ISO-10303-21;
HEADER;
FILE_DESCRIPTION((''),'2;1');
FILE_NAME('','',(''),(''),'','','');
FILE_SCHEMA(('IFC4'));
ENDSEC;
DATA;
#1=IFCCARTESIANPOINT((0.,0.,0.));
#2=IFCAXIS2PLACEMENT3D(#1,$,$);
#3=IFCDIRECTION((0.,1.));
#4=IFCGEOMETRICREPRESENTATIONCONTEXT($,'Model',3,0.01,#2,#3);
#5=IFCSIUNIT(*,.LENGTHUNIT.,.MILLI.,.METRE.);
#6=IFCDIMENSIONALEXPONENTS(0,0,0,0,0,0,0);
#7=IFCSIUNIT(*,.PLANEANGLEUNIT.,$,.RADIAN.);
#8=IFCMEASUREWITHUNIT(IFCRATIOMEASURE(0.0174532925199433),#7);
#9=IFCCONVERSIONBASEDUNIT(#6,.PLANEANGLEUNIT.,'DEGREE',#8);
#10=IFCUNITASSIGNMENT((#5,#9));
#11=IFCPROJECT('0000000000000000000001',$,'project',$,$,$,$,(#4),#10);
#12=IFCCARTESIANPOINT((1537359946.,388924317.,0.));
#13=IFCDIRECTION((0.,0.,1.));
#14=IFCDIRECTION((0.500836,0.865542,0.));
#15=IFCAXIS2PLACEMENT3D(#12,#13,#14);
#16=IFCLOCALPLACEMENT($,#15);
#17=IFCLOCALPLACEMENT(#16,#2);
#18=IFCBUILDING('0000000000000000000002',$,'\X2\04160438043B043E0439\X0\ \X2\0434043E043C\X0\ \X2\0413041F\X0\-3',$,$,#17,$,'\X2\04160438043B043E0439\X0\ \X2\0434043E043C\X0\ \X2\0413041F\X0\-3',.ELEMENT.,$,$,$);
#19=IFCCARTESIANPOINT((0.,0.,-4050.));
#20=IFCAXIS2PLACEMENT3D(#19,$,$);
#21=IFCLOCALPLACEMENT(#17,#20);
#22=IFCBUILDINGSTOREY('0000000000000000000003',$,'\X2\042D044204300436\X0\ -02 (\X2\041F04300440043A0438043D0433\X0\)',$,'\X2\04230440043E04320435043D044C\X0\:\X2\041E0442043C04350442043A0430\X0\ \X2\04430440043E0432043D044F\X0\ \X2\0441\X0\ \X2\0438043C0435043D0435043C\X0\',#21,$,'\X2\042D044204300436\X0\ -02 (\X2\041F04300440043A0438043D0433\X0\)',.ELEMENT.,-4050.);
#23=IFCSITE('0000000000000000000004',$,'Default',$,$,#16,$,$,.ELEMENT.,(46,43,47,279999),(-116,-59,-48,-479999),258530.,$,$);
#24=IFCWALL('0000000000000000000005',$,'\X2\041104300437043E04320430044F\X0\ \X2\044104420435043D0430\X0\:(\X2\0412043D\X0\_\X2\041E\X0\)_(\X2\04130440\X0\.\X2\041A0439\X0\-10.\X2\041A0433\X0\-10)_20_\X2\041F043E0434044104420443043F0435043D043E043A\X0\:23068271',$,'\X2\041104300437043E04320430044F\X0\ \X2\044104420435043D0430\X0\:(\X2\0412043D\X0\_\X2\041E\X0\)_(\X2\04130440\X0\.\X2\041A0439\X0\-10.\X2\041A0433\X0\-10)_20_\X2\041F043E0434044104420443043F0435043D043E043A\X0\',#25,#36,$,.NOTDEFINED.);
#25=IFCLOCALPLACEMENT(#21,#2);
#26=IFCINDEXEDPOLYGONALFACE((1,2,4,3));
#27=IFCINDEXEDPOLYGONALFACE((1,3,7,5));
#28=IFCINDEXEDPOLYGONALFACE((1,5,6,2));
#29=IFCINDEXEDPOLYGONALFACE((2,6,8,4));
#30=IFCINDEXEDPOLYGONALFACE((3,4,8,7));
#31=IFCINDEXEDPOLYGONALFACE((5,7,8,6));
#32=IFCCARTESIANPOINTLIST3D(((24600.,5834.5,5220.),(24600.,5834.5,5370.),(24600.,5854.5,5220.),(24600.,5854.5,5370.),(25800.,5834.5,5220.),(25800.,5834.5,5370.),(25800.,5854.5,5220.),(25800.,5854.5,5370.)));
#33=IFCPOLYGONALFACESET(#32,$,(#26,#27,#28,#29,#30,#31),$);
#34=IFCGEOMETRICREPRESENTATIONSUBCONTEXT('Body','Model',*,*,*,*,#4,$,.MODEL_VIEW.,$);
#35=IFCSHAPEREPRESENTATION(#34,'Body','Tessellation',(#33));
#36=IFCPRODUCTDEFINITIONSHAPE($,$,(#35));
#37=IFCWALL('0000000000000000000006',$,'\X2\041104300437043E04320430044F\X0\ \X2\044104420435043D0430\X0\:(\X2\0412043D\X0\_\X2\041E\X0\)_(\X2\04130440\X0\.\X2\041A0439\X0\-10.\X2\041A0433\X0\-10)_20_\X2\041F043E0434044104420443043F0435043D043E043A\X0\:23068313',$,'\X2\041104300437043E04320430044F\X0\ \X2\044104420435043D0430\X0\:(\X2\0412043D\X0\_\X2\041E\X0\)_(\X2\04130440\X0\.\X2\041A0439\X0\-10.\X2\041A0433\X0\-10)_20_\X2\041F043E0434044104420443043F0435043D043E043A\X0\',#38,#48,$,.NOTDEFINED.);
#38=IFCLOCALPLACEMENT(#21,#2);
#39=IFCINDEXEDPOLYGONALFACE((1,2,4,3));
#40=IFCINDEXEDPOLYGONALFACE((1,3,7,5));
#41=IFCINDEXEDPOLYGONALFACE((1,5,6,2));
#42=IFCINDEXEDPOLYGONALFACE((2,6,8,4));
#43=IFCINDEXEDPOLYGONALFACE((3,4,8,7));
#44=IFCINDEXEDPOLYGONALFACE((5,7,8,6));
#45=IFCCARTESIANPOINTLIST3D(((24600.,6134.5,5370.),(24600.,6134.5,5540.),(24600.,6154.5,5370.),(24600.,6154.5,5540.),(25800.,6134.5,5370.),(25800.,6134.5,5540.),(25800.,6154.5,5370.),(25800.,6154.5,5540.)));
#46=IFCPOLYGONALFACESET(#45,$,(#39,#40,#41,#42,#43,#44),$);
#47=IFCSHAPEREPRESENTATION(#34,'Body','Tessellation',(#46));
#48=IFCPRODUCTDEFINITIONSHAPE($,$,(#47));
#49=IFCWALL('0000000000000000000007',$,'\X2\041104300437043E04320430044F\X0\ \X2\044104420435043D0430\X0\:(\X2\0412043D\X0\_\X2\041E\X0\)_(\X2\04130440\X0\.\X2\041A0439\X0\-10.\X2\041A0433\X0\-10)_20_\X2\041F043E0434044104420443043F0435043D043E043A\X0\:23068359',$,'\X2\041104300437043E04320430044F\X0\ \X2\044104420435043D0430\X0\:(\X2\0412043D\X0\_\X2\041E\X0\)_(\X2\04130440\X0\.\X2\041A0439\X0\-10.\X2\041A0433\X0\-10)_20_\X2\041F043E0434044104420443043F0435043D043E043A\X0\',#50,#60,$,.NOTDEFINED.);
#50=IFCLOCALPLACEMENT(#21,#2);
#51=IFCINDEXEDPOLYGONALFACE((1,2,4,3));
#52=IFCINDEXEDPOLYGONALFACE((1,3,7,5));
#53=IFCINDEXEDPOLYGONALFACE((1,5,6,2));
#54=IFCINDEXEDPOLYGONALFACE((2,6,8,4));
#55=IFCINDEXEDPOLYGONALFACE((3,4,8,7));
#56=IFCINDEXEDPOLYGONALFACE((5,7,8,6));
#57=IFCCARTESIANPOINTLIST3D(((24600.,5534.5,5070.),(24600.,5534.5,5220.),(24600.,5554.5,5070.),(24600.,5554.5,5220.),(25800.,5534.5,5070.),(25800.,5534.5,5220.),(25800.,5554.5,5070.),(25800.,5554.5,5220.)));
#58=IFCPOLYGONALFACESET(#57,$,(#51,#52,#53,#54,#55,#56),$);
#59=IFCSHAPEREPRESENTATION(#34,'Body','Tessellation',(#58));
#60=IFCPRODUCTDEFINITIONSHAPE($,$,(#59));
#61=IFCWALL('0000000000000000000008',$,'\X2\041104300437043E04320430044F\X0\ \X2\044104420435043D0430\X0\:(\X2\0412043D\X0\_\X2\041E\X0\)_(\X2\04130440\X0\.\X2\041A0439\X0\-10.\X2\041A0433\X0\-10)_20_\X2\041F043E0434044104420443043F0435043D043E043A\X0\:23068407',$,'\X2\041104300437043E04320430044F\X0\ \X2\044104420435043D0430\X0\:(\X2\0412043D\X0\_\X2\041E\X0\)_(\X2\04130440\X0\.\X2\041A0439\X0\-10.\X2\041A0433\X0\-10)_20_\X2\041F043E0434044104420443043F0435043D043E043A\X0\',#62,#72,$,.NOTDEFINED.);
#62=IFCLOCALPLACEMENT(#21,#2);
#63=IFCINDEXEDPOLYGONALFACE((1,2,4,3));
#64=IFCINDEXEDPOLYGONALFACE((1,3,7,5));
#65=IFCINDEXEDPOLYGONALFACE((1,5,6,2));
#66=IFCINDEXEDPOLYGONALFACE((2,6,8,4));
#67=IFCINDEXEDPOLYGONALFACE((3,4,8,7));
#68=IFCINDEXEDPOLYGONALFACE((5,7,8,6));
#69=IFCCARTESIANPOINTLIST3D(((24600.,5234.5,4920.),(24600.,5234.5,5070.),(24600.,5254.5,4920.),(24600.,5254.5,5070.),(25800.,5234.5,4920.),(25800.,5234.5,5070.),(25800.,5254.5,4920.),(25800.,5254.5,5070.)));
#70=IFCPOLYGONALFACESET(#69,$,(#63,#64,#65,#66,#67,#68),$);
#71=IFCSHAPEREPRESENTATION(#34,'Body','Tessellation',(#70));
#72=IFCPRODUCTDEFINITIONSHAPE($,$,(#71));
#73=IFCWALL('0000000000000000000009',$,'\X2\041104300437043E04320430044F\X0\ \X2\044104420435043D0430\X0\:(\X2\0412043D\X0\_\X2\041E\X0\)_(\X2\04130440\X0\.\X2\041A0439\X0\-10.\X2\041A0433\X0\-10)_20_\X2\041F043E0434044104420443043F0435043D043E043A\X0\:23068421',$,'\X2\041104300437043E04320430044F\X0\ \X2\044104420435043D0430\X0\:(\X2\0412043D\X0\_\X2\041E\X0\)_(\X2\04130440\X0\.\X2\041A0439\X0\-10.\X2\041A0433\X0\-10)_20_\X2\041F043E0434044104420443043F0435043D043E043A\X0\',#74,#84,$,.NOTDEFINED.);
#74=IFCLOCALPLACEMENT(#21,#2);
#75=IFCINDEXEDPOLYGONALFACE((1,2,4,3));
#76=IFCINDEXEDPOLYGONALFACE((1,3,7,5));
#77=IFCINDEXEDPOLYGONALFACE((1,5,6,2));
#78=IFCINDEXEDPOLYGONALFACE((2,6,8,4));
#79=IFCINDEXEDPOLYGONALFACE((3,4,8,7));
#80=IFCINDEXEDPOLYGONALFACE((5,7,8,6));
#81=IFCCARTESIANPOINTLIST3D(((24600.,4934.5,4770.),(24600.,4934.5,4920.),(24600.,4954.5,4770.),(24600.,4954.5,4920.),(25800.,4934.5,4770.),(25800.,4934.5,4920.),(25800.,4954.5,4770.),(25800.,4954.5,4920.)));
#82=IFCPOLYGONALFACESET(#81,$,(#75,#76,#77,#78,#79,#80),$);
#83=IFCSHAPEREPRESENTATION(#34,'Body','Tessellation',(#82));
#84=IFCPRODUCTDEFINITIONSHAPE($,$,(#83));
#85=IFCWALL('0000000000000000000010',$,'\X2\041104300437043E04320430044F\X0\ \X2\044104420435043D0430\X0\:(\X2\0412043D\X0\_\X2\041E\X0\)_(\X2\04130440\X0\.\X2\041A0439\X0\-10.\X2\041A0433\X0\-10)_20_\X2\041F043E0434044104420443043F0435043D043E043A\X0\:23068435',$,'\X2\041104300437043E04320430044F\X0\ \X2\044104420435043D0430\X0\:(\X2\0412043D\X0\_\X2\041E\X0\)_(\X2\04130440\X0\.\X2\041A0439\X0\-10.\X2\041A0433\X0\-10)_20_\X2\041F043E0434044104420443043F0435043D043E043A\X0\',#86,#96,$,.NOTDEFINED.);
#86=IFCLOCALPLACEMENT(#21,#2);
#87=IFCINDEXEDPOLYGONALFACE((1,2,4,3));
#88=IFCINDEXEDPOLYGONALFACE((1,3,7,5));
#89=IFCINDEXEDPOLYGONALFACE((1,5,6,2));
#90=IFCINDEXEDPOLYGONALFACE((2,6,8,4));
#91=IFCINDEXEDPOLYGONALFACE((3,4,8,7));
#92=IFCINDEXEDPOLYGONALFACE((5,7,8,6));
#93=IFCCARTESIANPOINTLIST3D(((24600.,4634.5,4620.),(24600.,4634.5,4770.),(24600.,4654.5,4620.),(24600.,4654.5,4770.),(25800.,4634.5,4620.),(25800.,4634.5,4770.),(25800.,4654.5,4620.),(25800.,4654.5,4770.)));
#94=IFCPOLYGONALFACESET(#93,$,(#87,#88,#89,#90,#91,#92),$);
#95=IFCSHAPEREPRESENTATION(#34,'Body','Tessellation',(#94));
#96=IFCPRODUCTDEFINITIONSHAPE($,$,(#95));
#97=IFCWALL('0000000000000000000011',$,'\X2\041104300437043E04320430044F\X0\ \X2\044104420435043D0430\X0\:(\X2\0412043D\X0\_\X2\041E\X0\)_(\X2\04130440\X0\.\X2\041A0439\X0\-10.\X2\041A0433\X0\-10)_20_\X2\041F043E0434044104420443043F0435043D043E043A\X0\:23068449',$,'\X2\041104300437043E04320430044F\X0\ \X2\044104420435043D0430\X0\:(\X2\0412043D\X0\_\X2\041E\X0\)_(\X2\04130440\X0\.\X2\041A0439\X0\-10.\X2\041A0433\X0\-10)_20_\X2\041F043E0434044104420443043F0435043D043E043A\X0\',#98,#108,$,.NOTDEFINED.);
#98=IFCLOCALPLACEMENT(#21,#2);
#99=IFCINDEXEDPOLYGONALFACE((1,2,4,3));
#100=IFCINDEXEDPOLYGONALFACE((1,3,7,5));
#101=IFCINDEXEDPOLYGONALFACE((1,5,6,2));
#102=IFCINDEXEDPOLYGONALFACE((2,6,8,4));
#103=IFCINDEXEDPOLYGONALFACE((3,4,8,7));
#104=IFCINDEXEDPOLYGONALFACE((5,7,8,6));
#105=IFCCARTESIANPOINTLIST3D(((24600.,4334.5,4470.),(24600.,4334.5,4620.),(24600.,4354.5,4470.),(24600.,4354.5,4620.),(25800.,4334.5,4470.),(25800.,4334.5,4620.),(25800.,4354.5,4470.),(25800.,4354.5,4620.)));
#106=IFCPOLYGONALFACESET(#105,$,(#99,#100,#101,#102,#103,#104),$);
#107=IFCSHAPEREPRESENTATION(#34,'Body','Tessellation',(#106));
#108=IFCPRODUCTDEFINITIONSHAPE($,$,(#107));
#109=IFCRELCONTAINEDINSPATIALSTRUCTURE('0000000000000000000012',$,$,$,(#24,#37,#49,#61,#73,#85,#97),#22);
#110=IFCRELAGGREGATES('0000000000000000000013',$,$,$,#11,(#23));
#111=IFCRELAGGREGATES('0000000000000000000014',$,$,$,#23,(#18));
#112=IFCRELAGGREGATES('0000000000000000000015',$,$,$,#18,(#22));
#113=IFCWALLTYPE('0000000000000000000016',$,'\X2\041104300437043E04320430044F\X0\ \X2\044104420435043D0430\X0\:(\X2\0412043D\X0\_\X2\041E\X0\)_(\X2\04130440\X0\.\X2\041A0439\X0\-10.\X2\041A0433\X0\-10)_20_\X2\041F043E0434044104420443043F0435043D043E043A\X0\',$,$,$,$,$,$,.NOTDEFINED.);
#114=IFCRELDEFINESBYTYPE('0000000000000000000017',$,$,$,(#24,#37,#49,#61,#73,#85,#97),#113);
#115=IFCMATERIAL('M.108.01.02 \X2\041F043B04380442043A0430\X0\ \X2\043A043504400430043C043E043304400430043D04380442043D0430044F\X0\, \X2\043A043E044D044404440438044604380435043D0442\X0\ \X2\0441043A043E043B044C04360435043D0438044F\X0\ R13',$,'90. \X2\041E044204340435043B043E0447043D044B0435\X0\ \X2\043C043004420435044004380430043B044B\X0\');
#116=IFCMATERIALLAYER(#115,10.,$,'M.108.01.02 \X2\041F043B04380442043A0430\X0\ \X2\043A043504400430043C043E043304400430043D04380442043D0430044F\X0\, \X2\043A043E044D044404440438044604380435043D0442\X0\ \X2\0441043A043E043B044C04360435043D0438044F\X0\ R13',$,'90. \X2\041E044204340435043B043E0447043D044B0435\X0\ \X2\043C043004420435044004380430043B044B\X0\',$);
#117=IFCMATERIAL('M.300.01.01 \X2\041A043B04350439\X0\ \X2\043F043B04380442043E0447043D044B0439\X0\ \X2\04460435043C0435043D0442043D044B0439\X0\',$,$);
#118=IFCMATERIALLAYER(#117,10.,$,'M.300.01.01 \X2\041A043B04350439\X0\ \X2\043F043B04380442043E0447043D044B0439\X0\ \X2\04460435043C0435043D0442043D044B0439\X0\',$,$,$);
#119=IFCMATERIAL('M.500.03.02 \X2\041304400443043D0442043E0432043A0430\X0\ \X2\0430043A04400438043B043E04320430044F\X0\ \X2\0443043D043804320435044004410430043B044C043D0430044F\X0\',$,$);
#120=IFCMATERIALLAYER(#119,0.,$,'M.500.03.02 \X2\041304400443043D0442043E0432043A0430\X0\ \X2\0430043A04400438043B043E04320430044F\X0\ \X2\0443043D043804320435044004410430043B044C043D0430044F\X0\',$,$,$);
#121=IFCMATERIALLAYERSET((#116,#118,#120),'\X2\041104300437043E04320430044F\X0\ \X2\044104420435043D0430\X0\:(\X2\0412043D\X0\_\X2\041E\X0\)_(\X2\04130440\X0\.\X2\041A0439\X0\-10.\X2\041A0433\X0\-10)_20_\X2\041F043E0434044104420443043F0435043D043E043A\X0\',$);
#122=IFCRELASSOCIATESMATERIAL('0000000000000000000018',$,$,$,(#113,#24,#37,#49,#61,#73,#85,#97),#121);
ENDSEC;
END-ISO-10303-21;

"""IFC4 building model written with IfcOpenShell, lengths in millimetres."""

from ifc_helpers import new_model, entity, si_unit, converted_unit, direction, frame, frame_2d, origin, place, context, subcontext, project, spatial, rectangle, extrude, material, layer, layer_set, layer_usage, type_object, element, save


model = new_model("IFC4")

# Units and contexts
model_context = context("Model", 3, precision=0.01, world=origin(), true_north=direction((0.0, 1.0)))
body_context = subcontext(model_context, "Body", "Model", "MODEL_VIEW")
ifc_project = project(units=[si_unit("LENGTHUNIT", "METRE", prefix="MILLI"), converted_unit("PLANEANGLEUNIT", "DEGREE", entity("IfcRatioMeasure", 0.0174532925199433), si_unit("PLANEANGLEUNIT", "RADIAN"), dimensions=[0, 0, 0, 0, 0, 0, 0])], contexts=[model_context])

# Site, building, storey
site_placement = place(None, frame((1537359946.0, 388924317.0, 0.0), z_axis=(0.0, 0.0, 1.0), x_axis=(0.500836, 0.865542, 0.0)))
site = spatial("IfcSite", under=ifc_project, at=site_placement, Name="Default", CompositionType="ELEMENT", RefLatitude=(46, 43, 47, 279999), RefLongitude=(-116, -59, -48, -479999), RefElevation=258530.0)
building_placement = place(site_placement, origin())
building = spatial("IfcBuilding", under=site, at=building_placement, Name="Жилой дом ГП-3", LongName="Жилой дом ГП-3", CompositionType="ELEMENT")
storey_placement = place(building_placement, frame((0.0, 0.0, -4050.0)))
storey = spatial("IfcBuildingStorey", under=building, at=storey_placement, Name="Этаж -02 (Паркинг)", ObjectType="Уровень:Отметка уровня с именем", LongName="Этаж -02 (Паркинг)", CompositionType="ELEMENT", Elevation=-4050.0)

# Walls
ifc_material_1 = material(Name="M.108.01.02 Плитка керамогранитная, коэффициент скольжения R13", Category="90. Отделочные материалы")
ifc_layer_1 = layer(ifc_material_1, 10.0, Name="M.108.01.02 Плитка керамогранитная, коэффициент скольжения R13", Category="90. Отделочные материалы")
ifc_material_2 = material(Name="M.300.01.01 Клей плиточный цементный")
ifc_layer_2 = layer(ifc_material_2, 10.0, Name="M.300.01.01 Клей плиточный цементный")
ifc_material_3 = material(Name="M.500.03.02 Грунтовка акриловая универсальная")
ifc_layer_3 = layer(ifc_material_3, 0.0, Name="M.500.03.02 Грунтовка акриловая универсальная")
ifc_layer_set = layer_set([ifc_layer_1, ifc_layer_2, ifc_layer_3], Name="Базовая стена:(Вн_О)_(Гр.Кй-10.Кг-10)_20_Подступенок")
ifc_layer_usage_1 = layer_usage(ifc_layer_set, "AXIS2", "NEGATIVE", 10.0)
wall_type = type_object("IfcWallType", Name="Базовая стена:(Вн_О)_(Гр.Кй-10.Кг-10)_20_Подступенок", PredefinedType="NOTDEFINED", material=ifc_layer_set)
wall_1_placement = place(storey_placement, frame((25800.0, 5844.5, 5220.0), z_axis=(0.0, 0.0, 1.0), x_axis=(-1.0, 0.0, 0.0)))
element("IfcWall", 1, at=wall_1_placement, inside=storey, type_object=wall_type, material=ifc_layer_usage_1, Name="Базовая стена:(Вн_О)_(Гр.Кй-10.Кг-10)_20_Подступенок:23068271", ObjectType="Базовая стена:(Вн_О)_(Гр.Кй-10.Кг-10)_20_Подступенок", PredefinedType="NOTDEFINED", context=body_context, shape_type="SweptSolid", body=[
    extrude(rectangle(XDim=1200.0, YDim=20.0, at=frame_2d((600.0, 0.0), x_axis=(-1.0, 0.0))), origin(), (0.0, 0.0, 1.0), 150.0),
])
ifc_layer_usage_2 = layer_usage(ifc_layer_set, "AXIS2", "NEGATIVE", 10.0)
wall_2_placement = place(storey_placement, frame((25800.0, 6144.5, 5370.0), z_axis=(0.0, 0.0, 1.0), x_axis=(-1.0, 0.0, 0.0)))
element("IfcWall", 2, at=wall_2_placement, inside=storey, type_object=wall_type, material=ifc_layer_usage_2, Name="Базовая стена:(Вн_О)_(Гр.Кй-10.Кг-10)_20_Подступенок:23068313", ObjectType="Базовая стена:(Вн_О)_(Гр.Кй-10.Кг-10)_20_Подступенок", PredefinedType="NOTDEFINED", context=body_context, shape_type="SweptSolid", body=[
    extrude(rectangle(XDim=1200.0, YDim=20.0, at=frame_2d((600.0, 0.0), x_axis=(-1.0, 0.0))), origin(), (0.0, 0.0, 1.0), 170.0),
])
ifc_layer_usage_3 = layer_usage(ifc_layer_set, "AXIS2", "NEGATIVE", 10.0)
wall_3_placement = place(storey_placement, frame((25800.0, 5544.5, 5070.0), z_axis=(0.0, 0.0, 1.0), x_axis=(-1.0, 0.0, 0.0)))
element("IfcWall", 3, at=wall_3_placement, inside=storey, type_object=wall_type, material=ifc_layer_usage_3, Name="Базовая стена:(Вн_О)_(Гр.Кй-10.Кг-10)_20_Подступенок:23068359", ObjectType="Базовая стена:(Вн_О)_(Гр.Кй-10.Кг-10)_20_Подступенок", PredefinedType="NOTDEFINED", context=body_context, shape_type="SweptSolid", body=[
    extrude(rectangle(XDim=1200.0, YDim=20.0, at=frame_2d((600.0, 0.0), x_axis=(-1.0, 0.0))), origin(), (0.0, 0.0, 1.0), 150.0),
])
ifc_layer_usage_4 = layer_usage(ifc_layer_set, "AXIS2", "NEGATIVE", 10.0)
wall_4_placement = place(storey_placement, frame((25800.0, 5244.5, 4920.0), z_axis=(0.0, 0.0, 1.0), x_axis=(-1.0, 0.0, 0.0)))
element("IfcWall", 4, at=wall_4_placement, inside=storey, type_object=wall_type, material=ifc_layer_usage_4, Name="Базовая стена:(Вн_О)_(Гр.Кй-10.Кг-10)_20_Подступенок:23068407", ObjectType="Базовая стена:(Вн_О)_(Гр.Кй-10.Кг-10)_20_Подступенок", PredefinedType="NOTDEFINED", context=body_context, shape_type="SweptSolid", body=[
    extrude(rectangle(XDim=1200.0, YDim=20.0, at=frame_2d((600.0, 0.0), x_axis=(-1.0, 0.0))), origin(), (0.0, 0.0, 1.0), 150.0),
])
ifc_layer_usage_5 = layer_usage(ifc_layer_set, "AXIS2", "NEGATIVE", 10.0)
wall_5_placement = place(storey_placement, frame((25800.0, 4944.5, 4770.0), z_axis=(0.0, 0.0, 1.0), x_axis=(-1.0, 0.0, 0.0)))
element("IfcWall", 5, at=wall_5_placement, inside=storey, type_object=wall_type, material=ifc_layer_usage_5, Name="Базовая стена:(Вн_О)_(Гр.Кй-10.Кг-10)_20_Подступенок:23068421", ObjectType="Базовая стена:(Вн_О)_(Гр.Кй-10.Кг-10)_20_Подступенок", PredefinedType="NOTDEFINED", context=body_context, shape_type="SweptSolid", body=[
    extrude(rectangle(XDim=1200.0, YDim=20.0, at=frame_2d((600.0, 0.0), x_axis=(-1.0, 0.0))), origin(), (0.0, 0.0, 1.0), 150.0),
])
ifc_layer_usage_6 = layer_usage(ifc_layer_set, "AXIS2", "NEGATIVE", 10.0)
wall_6_placement = place(storey_placement, frame((25800.0, 4644.5, 4620.0), z_axis=(0.0, 0.0, 1.0), x_axis=(-1.0, 0.0, 0.0)))
element("IfcWall", 6, at=wall_6_placement, inside=storey, type_object=wall_type, material=ifc_layer_usage_6, Name="Базовая стена:(Вн_О)_(Гр.Кй-10.Кг-10)_20_Подступенок:23068435", ObjectType="Базовая стена:(Вн_О)_(Гр.Кй-10.Кг-10)_20_Подступенок", PredefinedType="NOTDEFINED", context=body_context, shape_type="SweptSolid", body=[
    extrude(rectangle(XDim=1200.0, YDim=20.0, at=frame_2d((600.0, 0.0), x_axis=(-1.0, 0.0))), origin(), (0.0, 0.0, 1.0), 150.0),
])
ifc_layer_usage_7 = layer_usage(ifc_layer_set, "AXIS2", "NEGATIVE", 10.0)
wall_7_placement = place(storey_placement, frame((25800.0, 4344.5, 4470.0), z_axis=(0.0, 0.0, 1.0), x_axis=(-1.0, 0.0, 0.0)))
element("IfcWall", 7, at=wall_7_placement, inside=storey, type_object=wall_type, material=ifc_layer_usage_7, Name="Базовая стена:(Вн_О)_(Гр.Кй-10.Кг-10)_20_Подступенок:23068449", ObjectType="Базовая стена:(Вн_О)_(Гр.Кй-10.Кг-10)_20_Подступенок", PredefinedType="NOTDEFINED", context=body_context, shape_type="SweptSolid", body=[
    extrude(rectangle(XDim=1200.0, YDim=20.0, at=frame_2d((600.0, 0.0), x_axis=(-1.0, 0.0))), origin(), (0.0, 0.0, 1.0), 150.0),
])

save(model, "model.ifc")
